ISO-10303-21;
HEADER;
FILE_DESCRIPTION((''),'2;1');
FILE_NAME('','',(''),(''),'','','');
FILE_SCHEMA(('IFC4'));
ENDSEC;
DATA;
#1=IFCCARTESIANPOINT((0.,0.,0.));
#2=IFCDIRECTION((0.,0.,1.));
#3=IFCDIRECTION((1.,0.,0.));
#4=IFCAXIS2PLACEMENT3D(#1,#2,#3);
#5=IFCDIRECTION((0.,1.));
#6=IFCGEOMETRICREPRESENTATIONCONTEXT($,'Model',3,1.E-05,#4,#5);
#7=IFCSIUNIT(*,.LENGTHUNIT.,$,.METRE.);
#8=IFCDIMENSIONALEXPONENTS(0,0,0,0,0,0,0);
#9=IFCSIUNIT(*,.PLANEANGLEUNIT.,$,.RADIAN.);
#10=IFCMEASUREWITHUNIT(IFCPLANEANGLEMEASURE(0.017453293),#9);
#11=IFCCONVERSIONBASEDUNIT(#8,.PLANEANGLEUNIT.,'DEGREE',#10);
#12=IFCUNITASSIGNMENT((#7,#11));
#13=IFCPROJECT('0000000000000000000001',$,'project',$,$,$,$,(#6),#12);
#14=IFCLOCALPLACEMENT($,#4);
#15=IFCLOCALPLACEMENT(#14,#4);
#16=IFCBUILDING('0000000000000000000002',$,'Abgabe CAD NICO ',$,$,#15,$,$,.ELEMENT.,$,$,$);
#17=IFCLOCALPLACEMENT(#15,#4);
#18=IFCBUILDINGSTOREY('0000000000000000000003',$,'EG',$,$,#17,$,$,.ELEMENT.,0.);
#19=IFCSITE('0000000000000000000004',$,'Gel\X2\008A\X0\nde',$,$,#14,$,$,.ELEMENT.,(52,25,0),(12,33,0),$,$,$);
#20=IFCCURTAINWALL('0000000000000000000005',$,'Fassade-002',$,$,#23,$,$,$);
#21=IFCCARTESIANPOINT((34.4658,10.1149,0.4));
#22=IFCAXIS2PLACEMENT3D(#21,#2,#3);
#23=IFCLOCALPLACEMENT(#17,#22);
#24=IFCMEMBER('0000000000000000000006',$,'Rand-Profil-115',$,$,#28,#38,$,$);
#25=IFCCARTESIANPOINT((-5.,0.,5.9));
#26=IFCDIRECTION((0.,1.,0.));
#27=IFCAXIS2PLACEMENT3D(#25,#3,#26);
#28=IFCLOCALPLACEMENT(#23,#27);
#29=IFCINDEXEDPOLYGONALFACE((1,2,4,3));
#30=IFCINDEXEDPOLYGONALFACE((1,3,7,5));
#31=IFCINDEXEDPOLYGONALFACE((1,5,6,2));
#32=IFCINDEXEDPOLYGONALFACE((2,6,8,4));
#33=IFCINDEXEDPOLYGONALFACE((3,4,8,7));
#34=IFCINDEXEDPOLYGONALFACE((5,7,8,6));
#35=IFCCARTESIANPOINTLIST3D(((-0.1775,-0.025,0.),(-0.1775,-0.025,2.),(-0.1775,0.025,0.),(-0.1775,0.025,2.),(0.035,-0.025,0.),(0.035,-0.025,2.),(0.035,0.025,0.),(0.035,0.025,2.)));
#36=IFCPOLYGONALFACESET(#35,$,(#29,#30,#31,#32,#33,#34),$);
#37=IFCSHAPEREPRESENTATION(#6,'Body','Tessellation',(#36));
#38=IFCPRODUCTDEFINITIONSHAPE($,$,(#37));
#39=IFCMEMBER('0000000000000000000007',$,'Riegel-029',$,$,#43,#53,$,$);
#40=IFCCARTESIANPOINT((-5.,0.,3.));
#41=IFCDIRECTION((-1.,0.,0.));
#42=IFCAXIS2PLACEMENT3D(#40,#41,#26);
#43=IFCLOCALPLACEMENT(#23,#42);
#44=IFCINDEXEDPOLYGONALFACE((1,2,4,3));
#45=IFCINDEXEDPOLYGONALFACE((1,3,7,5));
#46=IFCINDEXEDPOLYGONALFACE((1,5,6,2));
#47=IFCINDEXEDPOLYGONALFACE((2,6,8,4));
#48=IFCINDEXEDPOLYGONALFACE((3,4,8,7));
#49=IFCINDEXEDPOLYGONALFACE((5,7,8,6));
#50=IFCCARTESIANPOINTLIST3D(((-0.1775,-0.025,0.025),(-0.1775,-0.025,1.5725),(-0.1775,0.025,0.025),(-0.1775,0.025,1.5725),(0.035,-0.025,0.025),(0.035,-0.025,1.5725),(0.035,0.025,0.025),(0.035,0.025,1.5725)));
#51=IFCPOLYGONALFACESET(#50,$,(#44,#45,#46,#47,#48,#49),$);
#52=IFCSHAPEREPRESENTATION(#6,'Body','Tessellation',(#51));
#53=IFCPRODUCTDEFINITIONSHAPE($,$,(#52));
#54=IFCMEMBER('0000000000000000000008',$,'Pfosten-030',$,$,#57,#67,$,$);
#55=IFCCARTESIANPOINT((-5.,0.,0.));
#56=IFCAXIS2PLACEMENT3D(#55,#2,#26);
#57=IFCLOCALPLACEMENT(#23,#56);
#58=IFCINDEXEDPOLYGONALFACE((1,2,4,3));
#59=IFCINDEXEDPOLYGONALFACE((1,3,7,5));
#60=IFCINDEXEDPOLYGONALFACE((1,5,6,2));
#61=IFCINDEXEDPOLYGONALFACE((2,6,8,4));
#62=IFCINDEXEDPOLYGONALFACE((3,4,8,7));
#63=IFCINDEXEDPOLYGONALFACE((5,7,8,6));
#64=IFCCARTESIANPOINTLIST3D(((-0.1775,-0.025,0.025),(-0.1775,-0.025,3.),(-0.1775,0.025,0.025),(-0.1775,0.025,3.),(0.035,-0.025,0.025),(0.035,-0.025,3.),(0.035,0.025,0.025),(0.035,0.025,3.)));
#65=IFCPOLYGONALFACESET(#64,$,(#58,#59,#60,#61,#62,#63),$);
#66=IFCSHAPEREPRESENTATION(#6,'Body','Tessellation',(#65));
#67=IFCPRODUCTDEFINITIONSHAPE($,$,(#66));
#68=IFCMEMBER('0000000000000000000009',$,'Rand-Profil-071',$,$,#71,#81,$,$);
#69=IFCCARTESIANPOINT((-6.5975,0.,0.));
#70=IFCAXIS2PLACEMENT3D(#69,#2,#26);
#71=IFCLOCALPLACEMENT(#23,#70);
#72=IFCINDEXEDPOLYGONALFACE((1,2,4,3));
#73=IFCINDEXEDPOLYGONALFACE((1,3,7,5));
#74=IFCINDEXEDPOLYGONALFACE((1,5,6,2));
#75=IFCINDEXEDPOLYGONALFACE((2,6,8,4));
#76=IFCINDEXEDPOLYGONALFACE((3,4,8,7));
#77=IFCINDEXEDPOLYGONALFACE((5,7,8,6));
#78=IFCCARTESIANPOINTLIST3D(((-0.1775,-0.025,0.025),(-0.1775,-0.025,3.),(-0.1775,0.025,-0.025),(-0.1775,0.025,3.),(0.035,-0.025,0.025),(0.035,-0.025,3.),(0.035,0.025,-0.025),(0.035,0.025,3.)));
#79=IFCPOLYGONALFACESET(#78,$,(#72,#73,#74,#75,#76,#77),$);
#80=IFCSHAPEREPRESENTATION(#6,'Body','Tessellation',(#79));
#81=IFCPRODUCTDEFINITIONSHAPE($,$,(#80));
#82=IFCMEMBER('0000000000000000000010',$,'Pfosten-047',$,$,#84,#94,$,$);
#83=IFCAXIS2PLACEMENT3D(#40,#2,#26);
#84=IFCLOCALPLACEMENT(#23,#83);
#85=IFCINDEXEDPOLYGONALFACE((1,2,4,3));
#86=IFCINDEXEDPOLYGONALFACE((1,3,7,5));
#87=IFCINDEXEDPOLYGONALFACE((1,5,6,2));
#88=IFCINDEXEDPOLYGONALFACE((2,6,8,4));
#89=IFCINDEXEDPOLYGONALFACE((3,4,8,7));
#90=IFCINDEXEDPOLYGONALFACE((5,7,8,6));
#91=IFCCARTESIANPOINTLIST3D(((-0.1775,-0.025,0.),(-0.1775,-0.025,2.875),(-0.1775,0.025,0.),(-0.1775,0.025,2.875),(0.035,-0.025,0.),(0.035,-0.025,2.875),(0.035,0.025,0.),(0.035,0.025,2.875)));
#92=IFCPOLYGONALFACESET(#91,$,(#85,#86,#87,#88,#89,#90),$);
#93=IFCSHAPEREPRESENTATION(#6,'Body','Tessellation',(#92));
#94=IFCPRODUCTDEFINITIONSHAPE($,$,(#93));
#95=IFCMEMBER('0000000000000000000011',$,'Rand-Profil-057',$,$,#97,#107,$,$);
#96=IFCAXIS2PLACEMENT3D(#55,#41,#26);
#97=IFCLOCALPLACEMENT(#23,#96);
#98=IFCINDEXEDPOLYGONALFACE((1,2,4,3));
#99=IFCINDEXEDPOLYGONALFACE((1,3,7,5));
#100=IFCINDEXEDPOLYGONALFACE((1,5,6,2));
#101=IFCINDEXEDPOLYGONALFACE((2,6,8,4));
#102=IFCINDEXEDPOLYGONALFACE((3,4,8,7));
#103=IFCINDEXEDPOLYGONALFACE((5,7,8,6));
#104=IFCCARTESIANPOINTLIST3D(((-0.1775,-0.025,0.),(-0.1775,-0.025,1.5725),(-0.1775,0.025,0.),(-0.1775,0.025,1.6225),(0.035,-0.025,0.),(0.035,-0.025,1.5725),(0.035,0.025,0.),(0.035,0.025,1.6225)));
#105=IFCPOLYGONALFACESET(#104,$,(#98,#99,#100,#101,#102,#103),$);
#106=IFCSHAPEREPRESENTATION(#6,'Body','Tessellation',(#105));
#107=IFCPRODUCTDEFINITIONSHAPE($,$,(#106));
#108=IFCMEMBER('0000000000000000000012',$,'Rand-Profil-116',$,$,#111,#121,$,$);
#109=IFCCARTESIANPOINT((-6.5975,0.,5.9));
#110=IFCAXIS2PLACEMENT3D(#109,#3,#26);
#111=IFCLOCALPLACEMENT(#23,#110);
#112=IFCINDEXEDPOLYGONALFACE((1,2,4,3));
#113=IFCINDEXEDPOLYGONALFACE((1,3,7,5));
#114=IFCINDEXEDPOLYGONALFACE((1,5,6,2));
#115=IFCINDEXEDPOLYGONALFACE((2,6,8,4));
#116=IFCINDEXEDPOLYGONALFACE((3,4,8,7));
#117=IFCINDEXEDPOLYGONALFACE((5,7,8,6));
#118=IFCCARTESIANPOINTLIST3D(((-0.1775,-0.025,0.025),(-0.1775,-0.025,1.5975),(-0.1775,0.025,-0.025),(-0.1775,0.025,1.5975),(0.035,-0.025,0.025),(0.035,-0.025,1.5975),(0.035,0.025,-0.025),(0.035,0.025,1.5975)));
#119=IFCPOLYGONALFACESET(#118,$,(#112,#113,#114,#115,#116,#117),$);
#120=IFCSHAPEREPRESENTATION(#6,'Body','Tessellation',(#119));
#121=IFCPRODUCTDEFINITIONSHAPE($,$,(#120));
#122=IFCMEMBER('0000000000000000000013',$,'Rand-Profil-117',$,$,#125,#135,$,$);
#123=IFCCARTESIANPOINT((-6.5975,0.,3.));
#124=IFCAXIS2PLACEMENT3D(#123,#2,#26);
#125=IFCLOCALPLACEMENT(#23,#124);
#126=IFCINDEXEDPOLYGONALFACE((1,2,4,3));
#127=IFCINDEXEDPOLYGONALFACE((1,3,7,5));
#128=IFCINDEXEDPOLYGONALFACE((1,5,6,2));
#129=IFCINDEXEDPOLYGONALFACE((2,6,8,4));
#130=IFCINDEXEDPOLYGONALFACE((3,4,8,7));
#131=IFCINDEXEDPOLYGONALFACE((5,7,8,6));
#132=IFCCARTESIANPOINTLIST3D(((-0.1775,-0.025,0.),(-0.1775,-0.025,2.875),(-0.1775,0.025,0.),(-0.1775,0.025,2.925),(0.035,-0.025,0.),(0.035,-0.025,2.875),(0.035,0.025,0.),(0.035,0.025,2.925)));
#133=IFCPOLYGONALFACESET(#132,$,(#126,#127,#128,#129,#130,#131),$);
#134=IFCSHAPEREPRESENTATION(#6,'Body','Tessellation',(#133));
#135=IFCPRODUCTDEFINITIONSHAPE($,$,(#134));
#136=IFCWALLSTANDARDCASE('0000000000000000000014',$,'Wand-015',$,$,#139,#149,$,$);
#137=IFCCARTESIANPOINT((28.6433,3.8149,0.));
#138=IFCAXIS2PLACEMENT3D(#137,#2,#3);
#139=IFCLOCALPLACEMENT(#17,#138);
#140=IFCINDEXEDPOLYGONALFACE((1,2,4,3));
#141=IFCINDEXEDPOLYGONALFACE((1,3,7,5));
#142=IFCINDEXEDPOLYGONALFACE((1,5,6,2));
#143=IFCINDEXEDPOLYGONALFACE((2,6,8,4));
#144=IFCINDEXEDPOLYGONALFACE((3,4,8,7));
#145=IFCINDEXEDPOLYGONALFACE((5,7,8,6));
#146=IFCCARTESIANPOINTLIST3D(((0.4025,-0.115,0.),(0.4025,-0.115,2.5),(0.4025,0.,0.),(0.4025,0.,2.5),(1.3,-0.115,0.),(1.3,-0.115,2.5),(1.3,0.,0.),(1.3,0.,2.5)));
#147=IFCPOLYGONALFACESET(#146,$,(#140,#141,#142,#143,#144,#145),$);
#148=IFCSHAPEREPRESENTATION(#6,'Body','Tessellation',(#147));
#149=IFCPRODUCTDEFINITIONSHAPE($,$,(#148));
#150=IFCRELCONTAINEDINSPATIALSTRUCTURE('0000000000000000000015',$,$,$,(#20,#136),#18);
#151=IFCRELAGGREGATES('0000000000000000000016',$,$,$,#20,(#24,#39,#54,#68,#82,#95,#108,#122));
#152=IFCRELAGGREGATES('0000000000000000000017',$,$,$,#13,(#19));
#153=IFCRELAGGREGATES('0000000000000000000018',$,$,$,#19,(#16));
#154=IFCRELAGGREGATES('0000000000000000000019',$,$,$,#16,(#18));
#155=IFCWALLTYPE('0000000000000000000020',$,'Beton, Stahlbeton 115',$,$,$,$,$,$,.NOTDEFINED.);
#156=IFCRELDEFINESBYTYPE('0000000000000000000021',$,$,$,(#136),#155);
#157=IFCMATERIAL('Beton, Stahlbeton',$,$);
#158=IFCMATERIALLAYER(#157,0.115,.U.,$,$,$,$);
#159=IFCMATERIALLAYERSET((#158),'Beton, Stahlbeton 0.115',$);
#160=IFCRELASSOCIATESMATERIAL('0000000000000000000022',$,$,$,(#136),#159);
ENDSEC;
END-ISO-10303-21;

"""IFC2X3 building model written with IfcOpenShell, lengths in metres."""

from ifc_helpers import new_model, entity, si_unit, converted_unit, direction, frame, origin_with_axes, place, context, project, spatial, polyline, outline, extrude, clip, halfspace, material, layer, layer_set, layer_usage, type_object, element, aggregate, save


model = new_model("IFC2X3")

# Units and contexts
model_context = context("Model", 3, precision=1e-05, world=origin_with_axes(), true_north=direction((0.0, 1.0)))
ifc_project = project(units=[si_unit("LENGTHUNIT", "METRE"), converted_unit("PLANEANGLEUNIT", "DEGREE", entity("IfcPlaneAngleMeasure", 0.017453293), si_unit("PLANEANGLEUNIT", "RADIAN"), dimensions=[0, 0, 0, 0, 0, 0, 0])], contexts=[model_context])

# Site, building, storey
site_placement = place(None, origin_with_axes())
site = spatial("IfcSite", under=ifc_project, at=site_placement, Name="Gel\u008ande", CompositionType="ELEMENT", RefLatitude=(52, 25, 0), RefLongitude=(12, 33, 0))
building_placement = place(site_placement, origin_with_axes())
building = spatial("IfcBuilding", under=site, at=building_placement, Name="Abgabe CAD NICO ", CompositionType="ELEMENT")
storey_placement = place(building_placement, origin_with_axes())
storey = spatial("IfcBuildingStorey", under=building, at=storey_placement, Name="EG", CompositionType="ELEMENT", Elevation=0.0)

# Curtain wall, members
curtain_wall_placement = place(storey_placement, frame((34.4658, 10.1149, 0.4), z_axis=(0.0, 0.0, 1.0), x_axis=(1.0, 0.0, 0.0)))
curtain_wall = element("IfcCurtainWall", 1, at=curtain_wall_placement, inside=storey, Name="Fassade-002")
member_1_placement = place(curtain_wall_placement, frame((-5.0, 0.0, 5.9), z_axis=(1.0, 0.0, 0.0), x_axis=(0.0, 1.0, 0.0)))
member_1 = element("IfcMember", 2, at=member_1_placement, Name="Rand-Profil-115", context=model_context, shape_type="SweptSolid", body=[
    extrude(outline(polyline([(0.1775, 0.025), (-0.035, 0.025), (-0.035, -0.025), (0.1775, -0.025), (0.1775, 0.025)])), frame((0.0, 0.0, 0.0), z_axis=(0.0, 0.0, 1.0), x_axis=(-1.0, 0.0, 0.0)), (0.0, 0.0, 1.0), 2.0),
])
member_2_placement = place(curtain_wall_placement, frame((-5.0, 0.0, 3.0), z_axis=(-1.0, 0.0, 0.0), x_axis=(0.0, 1.0, 0.0)))
member_2 = element("IfcMember", 3, at=member_2_placement, Name="Riegel-029", context=model_context, shape_type="SweptSolid", body=[
    extrude(outline(polyline([(-0.1775, -0.025), (0.035, -0.025), (0.035, 0.025), (-0.1775, 0.025), (-0.1775, -0.025)])), frame((0.0, 0.0, 0.025), z_axis=(0.0, 0.0, 1.0), x_axis=(1.0, 0.0, 0.0)), (0.0, 0.0, 1.0), 1.5475),
])
member_3_placement = place(curtain_wall_placement, frame((-5.0, 0.0, 0.0), z_axis=(0.0, 0.0, 1.0), x_axis=(0.0, 1.0, 0.0)))
member_3 = element("IfcMember", 4, at=member_3_placement, Name="Pfosten-030", context=model_context, shape_type="SweptSolid", body=[
    extrude(outline(polyline([(0.025, -0.1775), (0.025, 0.035), (-0.025, 0.035), (-0.025, -0.1775), (0.025, -0.1775)])), frame((0.0, 0.0, 0.025), z_axis=(0.0, 0.0, 1.0), x_axis=(0.0, -1.0, 0.0)), (0.0, 0.0, 1.0), 2.975),
])
member_4_placement = place(curtain_wall_placement, frame((-6.5975, 0.0, 0.0), z_axis=(0.0, 0.0, 1.0), x_axis=(0.0, 1.0, 0.0)))
member_4 = element("IfcMember", 5, at=member_4_placement, Name="Rand-Profil-071", context=model_context, shape_type="Clipping", body=[
    clip(extrude(outline(polyline([(0.025, -0.1775), (0.025, 0.035), (-0.025, 0.035), (-0.025, -0.1775), (0.025, -0.1775)])), frame((0.0, 0.0, -0.025), z_axis=(0.0, 0.0, 1.0), x_axis=(0.0, -1.0, 0.0)), (0.0, 0.0, 1.0), 3.025), halfspace(frame((0.0, 0.0, 0.0), z_axis=(0.0, 0.707107, 0.707107), x_axis=(0.0, 0.707107, -0.707107)), True)),
])
member_5_placement = place(curtain_wall_placement, frame((-5.0, 0.0, 3.0), z_axis=(0.0, 0.0, 1.0), x_axis=(0.0, 1.0, 0.0)))
member_5 = element("IfcMember", 6, at=member_5_placement, Name="Pfosten-047", context=model_context, shape_type="SweptSolid", body=[
    extrude(outline(polyline([(0.025, -0.1775), (0.025, 0.035), (-0.025, 0.035), (-0.025, -0.1775), (0.025, -0.1775)])), frame((0.0, 0.0, 0.0), z_axis=(0.0, 0.0, 1.0), x_axis=(0.0, -1.0, 0.0)), (0.0, 0.0, 1.0), 2.875),
])
member_6_placement = place(curtain_wall_placement, frame((-5.0, 0.0, 0.0), z_axis=(-1.0, 0.0, 0.0), x_axis=(0.0, 1.0, 0.0)))
member_6 = element("IfcMember", 7, at=member_6_placement, Name="Rand-Profil-057", context=model_context, shape_type="Clipping", body=[
    clip(extrude(outline(polyline([(-0.1775, -0.025), (0.035, -0.025), (0.035, 0.025), (-0.1775, 0.025), (-0.1775, -0.025)])), origin_with_axes(), (0.0, 0.0, 1.0), 1.6225), halfspace(frame((0.0, -0.7987, 0.7987), z_axis=(0.0, 0.707107, -0.707107), x_axis=(0.0, -0.707107, -0.707107)), True)),
])
member_7_placement = place(curtain_wall_placement, frame((-6.5975, 0.0, 5.9), z_axis=(1.0, 0.0, 0.0), x_axis=(0.0, 1.0, 0.0)))
member_7 = element("IfcMember", 8, at=member_7_placement, Name="Rand-Profil-116", context=model_context, shape_type="Clipping", body=[
    clip(extrude(outline(polyline([(0.1775, 0.025), (-0.035, 0.025), (-0.035, -0.025), (0.1775, -0.025), (0.1775, 0.025)])), frame((0.0, 0.0, -0.025), z_axis=(0.0, 0.0, 1.0), x_axis=(-1.0, 0.0, 0.0)), (0.0, 0.0, 1.0), 1.6225), halfspace(frame((0.0, 0.0, 0.0), z_axis=(0.0, 0.707107, 0.707107), x_axis=(0.0, 0.707107, -0.707107)), True)),
])
member_8_placement = place(curtain_wall_placement, frame((-6.5975, 0.0, 3.0), z_axis=(0.0, 0.0, 1.0), x_axis=(0.0, 1.0, 0.0)))
member_8 = element("IfcMember", 9, at=member_8_placement, Name="Rand-Profil-117", context=model_context, shape_type="Clipping", body=[
    clip(extrude(outline(polyline([(0.025, -0.1775), (0.025, 0.035), (-0.025, 0.035), (-0.025, -0.1775), (0.025, -0.1775)])), frame((0.0, 0.0, 0.0), z_axis=(0.0, 0.0, 1.0), x_axis=(0.0, -1.0, 0.0)), (0.0, 0.0, 1.0), 2.925), halfspace(frame((0.0, -1.45, 1.45), z_axis=(0.0, 0.707107, -0.707107), x_axis=(0.0, -0.707107, -0.707107)), True)),
])

# Shared definitions
ifc_material_1 = material(Name="Beton, Stahlbeton")

aggregate(curtain_wall, [member_1, member_2, member_3, member_4, member_5, member_6, member_7, member_8])

# Wall
ifc_layer_1 = layer(ifc_material_1, 0.115, ventilated="UNKNOWN")
ifc_layer_set_1 = layer_set([ifc_layer_1], Name="Beton, Stahlbeton 0.115")
ifc_layer_usage_1 = layer_usage(ifc_layer_set_1, "AXIS2", "NEGATIVE", 0.0)
wall_type_1 = type_object("IfcWallType", Name="Beton, Stahlbeton 115", PredefinedType="NOTDEFINED")
wall_1_placement = place(storey_placement, frame((28.6433, 3.8149, 0.0), z_axis=(0.0, 0.0, 1.0), x_axis=(1.0, 0.0, 0.0)))
element("IfcWallStandardCase", 10, at=wall_1_placement, inside=storey, type_object=wall_type_1, material=ifc_layer_usage_1, Name="Wand-015", context=model_context, shape_type="SweptSolid", body=[
    extrude(outline(polyline([(0.4025, -0.115), (1.3, -0.115), (1.3, 0.0), (0.4025, 0.0), (0.4025, -0.115)])), origin_with_axes(), (0.0, 0.0, 1.0), 2.5),
])

save(model, "model.ifc")
